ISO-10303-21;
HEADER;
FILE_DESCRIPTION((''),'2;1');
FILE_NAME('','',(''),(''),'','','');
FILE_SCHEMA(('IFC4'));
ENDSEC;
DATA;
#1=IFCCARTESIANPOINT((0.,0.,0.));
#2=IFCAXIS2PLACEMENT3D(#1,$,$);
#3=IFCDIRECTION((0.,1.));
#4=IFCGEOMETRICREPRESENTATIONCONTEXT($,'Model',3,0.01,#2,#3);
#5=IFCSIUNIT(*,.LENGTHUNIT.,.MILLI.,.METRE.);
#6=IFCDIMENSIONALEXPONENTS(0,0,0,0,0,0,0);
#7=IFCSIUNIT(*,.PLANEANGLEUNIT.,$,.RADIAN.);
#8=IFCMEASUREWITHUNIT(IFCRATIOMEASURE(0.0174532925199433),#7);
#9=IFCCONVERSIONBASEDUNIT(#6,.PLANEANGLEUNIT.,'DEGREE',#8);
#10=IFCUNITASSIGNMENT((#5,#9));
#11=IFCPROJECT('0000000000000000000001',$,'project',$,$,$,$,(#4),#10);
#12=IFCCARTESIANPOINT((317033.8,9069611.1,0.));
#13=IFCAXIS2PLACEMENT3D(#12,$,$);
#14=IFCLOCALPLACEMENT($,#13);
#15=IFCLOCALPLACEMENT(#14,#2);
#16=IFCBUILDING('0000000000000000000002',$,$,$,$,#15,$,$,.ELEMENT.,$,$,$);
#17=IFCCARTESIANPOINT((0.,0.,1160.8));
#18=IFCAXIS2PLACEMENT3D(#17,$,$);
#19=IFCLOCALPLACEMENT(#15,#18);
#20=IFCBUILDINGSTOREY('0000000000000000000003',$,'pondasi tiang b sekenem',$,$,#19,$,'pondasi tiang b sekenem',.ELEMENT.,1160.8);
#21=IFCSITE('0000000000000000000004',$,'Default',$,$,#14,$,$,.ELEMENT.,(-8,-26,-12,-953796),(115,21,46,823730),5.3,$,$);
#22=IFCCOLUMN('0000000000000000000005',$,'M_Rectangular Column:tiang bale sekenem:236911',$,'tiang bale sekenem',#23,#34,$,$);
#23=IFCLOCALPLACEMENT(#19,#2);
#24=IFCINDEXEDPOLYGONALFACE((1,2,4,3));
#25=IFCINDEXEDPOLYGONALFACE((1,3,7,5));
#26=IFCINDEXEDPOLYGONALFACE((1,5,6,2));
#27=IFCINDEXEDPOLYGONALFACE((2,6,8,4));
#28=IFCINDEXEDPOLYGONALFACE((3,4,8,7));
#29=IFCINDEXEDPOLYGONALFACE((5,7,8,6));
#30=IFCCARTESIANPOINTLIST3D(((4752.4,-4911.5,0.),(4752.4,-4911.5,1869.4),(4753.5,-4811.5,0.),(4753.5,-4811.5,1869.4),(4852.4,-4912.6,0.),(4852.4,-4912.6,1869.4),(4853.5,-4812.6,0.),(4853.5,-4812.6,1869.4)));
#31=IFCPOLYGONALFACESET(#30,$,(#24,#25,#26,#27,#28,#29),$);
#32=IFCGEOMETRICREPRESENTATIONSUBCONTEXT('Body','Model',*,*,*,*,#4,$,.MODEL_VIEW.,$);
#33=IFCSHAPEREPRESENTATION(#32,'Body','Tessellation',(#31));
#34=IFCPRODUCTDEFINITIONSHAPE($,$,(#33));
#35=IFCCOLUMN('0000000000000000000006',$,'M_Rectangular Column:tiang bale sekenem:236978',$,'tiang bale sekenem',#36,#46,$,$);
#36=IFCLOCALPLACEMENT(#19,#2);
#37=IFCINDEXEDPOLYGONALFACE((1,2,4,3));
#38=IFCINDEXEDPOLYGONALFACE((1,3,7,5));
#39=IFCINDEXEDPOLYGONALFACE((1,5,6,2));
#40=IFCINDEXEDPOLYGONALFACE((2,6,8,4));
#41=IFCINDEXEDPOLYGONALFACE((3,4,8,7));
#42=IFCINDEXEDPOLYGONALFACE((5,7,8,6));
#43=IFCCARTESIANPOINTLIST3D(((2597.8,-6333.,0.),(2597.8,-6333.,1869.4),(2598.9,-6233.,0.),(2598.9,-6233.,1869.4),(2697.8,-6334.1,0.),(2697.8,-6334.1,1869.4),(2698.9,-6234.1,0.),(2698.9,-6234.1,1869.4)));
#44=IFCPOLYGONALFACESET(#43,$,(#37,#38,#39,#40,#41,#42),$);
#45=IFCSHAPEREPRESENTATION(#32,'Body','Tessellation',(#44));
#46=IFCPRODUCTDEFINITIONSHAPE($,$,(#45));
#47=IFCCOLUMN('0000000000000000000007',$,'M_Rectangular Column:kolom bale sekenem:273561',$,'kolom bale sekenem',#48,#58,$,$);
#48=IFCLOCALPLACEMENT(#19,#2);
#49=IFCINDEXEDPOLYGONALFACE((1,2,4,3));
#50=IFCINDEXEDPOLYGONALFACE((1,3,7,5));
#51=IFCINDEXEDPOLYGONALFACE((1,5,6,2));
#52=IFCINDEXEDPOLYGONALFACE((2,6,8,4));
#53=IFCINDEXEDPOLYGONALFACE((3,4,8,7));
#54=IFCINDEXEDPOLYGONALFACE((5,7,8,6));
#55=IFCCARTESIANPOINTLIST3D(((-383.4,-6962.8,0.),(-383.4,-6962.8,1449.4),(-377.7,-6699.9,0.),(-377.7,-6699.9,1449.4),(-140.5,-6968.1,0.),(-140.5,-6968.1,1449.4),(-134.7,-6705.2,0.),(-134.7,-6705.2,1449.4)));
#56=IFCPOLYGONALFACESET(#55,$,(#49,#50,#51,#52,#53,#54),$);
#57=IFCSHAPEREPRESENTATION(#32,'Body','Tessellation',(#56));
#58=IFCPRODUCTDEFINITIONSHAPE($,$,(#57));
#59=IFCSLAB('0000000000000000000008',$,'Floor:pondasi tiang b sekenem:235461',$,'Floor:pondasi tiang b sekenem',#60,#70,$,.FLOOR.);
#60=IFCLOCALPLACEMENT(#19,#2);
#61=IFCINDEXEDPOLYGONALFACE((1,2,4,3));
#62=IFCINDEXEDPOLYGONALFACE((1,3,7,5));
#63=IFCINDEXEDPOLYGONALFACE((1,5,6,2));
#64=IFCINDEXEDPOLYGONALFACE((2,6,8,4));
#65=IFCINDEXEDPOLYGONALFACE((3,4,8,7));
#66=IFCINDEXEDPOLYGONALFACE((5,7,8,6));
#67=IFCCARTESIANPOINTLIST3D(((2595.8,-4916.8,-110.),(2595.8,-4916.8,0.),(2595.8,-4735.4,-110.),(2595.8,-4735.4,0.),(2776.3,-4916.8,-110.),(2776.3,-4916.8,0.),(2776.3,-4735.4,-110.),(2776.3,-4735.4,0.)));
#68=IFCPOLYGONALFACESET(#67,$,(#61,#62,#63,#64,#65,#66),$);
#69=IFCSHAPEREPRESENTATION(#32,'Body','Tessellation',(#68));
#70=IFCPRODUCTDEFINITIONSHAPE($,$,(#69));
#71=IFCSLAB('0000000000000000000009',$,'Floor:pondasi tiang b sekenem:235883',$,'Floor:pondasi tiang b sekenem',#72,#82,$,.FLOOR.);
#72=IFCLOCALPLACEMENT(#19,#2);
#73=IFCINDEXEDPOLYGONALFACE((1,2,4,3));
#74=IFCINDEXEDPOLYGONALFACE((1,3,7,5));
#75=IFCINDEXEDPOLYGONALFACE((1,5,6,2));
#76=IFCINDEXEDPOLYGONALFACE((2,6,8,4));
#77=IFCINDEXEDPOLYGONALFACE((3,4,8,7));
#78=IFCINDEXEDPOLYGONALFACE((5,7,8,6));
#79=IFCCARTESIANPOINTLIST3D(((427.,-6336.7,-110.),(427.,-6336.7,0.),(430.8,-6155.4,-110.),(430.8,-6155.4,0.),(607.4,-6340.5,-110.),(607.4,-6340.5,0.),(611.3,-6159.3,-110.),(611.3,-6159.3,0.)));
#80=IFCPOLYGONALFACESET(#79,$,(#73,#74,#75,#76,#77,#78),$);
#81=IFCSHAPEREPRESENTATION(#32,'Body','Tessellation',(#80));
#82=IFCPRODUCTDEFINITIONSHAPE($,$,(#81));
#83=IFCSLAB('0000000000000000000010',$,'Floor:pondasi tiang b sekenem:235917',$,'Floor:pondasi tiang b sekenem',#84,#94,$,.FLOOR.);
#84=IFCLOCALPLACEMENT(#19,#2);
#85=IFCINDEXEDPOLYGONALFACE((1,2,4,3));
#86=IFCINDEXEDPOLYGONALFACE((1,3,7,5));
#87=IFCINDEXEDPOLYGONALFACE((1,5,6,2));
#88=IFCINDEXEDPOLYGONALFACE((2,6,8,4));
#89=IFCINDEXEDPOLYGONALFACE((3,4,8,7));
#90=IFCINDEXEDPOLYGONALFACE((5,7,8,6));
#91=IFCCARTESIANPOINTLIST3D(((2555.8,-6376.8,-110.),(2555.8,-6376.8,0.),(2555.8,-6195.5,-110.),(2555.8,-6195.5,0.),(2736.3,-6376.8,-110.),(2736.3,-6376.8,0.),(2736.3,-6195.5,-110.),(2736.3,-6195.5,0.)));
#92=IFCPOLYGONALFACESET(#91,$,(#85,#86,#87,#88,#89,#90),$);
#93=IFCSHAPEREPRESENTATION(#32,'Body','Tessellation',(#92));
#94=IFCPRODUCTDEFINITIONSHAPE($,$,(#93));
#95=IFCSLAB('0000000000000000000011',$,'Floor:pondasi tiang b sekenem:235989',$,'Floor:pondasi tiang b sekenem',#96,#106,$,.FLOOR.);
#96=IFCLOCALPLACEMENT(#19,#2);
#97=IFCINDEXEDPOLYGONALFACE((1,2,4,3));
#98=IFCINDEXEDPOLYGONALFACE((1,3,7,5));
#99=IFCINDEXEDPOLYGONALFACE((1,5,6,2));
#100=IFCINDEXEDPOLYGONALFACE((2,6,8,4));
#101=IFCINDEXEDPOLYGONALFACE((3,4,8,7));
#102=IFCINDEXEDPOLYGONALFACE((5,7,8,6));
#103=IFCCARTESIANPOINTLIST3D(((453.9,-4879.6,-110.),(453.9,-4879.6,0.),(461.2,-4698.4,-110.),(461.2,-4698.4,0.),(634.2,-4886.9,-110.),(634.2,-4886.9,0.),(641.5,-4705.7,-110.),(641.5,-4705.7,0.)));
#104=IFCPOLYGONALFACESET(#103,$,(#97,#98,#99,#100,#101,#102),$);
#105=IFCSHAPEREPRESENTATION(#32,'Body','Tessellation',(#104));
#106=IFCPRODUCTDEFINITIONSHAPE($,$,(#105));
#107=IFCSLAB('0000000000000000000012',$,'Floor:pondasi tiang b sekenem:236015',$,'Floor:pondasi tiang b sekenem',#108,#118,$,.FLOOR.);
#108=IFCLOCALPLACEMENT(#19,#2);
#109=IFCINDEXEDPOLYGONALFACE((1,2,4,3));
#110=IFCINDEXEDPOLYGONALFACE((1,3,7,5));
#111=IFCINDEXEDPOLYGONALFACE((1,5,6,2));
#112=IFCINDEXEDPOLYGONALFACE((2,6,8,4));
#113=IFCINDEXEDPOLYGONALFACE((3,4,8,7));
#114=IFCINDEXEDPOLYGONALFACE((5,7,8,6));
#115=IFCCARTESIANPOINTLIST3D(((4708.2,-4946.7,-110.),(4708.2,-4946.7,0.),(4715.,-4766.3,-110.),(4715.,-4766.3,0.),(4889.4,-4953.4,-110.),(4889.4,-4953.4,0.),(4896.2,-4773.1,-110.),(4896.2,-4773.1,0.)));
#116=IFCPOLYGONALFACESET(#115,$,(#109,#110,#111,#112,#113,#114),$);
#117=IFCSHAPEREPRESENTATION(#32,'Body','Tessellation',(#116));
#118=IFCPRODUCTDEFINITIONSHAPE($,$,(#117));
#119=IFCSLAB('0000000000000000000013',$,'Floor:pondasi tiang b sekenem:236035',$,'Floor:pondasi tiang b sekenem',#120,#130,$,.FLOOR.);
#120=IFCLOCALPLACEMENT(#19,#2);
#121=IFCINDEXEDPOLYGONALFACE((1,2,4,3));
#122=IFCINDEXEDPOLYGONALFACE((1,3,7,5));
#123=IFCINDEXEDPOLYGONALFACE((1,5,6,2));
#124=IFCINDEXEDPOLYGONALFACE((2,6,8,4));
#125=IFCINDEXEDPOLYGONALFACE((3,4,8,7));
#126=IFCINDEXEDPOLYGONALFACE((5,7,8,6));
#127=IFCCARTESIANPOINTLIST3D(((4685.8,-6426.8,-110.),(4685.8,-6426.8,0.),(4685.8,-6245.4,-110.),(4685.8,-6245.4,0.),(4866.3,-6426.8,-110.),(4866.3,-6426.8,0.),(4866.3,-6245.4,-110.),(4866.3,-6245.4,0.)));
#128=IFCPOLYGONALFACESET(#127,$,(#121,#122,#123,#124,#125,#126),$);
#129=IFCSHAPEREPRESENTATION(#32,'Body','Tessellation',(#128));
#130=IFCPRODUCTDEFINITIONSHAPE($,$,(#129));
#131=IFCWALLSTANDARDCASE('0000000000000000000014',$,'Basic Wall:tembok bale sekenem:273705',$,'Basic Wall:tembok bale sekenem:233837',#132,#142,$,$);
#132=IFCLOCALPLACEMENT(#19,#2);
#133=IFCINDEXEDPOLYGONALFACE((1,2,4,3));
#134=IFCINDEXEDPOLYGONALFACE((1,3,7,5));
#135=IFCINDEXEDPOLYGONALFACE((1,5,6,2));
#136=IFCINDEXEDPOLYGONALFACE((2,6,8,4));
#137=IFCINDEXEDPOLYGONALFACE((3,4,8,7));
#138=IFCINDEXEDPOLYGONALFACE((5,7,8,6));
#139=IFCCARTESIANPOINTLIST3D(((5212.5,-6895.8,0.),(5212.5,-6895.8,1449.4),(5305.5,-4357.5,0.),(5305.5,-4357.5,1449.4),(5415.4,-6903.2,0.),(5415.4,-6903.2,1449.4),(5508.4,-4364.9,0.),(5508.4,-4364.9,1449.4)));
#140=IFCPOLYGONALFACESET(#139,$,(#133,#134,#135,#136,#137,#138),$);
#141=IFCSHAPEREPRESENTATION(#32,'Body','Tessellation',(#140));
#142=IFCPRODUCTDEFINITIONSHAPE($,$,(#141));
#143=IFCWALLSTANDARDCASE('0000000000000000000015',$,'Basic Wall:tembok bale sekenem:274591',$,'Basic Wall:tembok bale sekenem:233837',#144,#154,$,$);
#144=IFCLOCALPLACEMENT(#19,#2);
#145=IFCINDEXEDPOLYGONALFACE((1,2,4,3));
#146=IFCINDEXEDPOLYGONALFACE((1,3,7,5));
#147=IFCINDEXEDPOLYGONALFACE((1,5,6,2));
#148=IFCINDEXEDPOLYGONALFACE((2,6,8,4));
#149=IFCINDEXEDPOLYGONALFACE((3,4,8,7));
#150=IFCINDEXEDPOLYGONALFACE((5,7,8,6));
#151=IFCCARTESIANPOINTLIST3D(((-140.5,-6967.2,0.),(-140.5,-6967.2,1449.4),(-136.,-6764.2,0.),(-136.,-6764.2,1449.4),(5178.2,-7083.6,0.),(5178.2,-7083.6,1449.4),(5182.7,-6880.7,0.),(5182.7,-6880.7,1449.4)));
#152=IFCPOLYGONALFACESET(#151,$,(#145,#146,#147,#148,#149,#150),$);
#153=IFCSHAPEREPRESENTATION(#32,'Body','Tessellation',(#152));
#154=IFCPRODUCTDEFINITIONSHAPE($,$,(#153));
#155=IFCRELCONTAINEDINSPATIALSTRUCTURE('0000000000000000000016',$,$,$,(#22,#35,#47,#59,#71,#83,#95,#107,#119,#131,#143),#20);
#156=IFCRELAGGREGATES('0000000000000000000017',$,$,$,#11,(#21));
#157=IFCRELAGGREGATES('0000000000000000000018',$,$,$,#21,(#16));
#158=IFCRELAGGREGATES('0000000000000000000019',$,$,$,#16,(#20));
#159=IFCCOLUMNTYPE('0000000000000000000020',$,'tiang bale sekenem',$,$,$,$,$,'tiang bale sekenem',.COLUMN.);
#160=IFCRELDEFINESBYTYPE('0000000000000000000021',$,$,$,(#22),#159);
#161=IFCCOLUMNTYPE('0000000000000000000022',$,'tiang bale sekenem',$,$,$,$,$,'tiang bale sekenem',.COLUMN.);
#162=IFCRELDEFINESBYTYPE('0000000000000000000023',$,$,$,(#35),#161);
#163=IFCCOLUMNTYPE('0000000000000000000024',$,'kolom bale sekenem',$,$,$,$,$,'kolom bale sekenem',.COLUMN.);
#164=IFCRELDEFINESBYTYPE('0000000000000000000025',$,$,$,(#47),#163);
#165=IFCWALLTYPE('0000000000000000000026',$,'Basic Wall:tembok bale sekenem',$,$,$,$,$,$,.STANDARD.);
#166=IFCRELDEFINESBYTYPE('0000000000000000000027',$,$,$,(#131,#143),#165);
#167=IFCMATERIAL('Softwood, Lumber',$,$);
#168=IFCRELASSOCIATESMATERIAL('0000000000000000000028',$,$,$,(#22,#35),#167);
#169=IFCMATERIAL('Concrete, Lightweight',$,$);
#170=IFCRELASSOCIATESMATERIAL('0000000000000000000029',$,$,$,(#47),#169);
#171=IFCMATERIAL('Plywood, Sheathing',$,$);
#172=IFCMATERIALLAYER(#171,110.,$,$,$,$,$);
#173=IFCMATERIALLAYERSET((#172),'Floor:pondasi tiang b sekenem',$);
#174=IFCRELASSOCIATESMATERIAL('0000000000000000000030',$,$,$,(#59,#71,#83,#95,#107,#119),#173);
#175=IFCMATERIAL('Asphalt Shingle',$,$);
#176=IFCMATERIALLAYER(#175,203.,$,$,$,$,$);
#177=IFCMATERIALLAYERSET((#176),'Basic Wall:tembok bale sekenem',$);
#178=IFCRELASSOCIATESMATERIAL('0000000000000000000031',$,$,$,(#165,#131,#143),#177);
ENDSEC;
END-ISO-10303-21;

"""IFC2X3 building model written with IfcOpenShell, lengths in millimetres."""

from ifc_helpers import new_model, entity, si_unit, converted_unit, direction, frame, frame_2d, origin, origin_2d_with_axis, place, context, subcontext, project, spatial, rectangle, extrude, source, transform, mapped, material, layer, layer_set, layer_usage, type_object, type_shapes, element, save


model = new_model("IFC2X3")

# Units and contexts
model_context = context("Model", 3, precision=0.01, world=origin(), true_north=direction((0.0, 1.0)))
body_context = subcontext(model_context, "Body", "Model", "MODEL_VIEW")
ifc_project = project(units=[si_unit("LENGTHUNIT", "METRE", prefix="MILLI"), converted_unit("PLANEANGLEUNIT", "DEGREE", entity("IfcRatioMeasure", 0.0174532925199433), si_unit("PLANEANGLEUNIT", "RADIAN"), dimensions=[0, 0, 0, 0, 0, 0, 0])], contexts=[model_context])

# Site, building, storey
site_placement = place(None, frame((317033.8, 9069611.1, 0.0)))
site = spatial("IfcSite", under=ifc_project, at=site_placement, Name="Default", CompositionType="ELEMENT", RefLatitude=(-8, -26, -12, -953796), RefLongitude=(115, 21, 46, 823730), RefElevation=5.3)
building_placement = place(site_placement, origin())
building = spatial("IfcBuilding", under=site, at=building_placement, CompositionType="ELEMENT")
storey_placement = place(building_placement, frame((0.0, 0.0, 1160.8)))
storey = spatial("IfcBuildingStorey", under=building, at=storey_placement, Name="pondasi tiang b sekenem", LongName="pondasi tiang b sekenem", CompositionType="ELEMENT", Elevation=1160.8)

# Columns
ifc_material_1 = material(Name="Softwood, Lumber")
column_type_1 = type_object("IfcColumnType", Name="tiang bale sekenem", ElementType="tiang bale sekenem", PredefinedType="COLUMN")
shared_shape_1 = source(origin(), body_context, "Body", "SweptSolid", [
    extrude(rectangle(XDim=100.0, YDim=100.0, at=frame_2d((0.0, 0.0), x_axis=(1.0, 0.0))), frame((4803.0, -4862.1, 1160.8), z_axis=(0.0, 0.0, 1.0), x_axis=(-0.999937, 0.011261, 0.0)), (0.0, 0.0, 1.0), 1869.4),
])
type_shapes(column_type_1, [shared_shape_1])
column_1_placement = place(storey_placement, frame((0.0, 0.0, -1160.8)))
element("IfcColumn", 1, at=column_1_placement, inside=storey, type_object=column_type_1, material=ifc_material_1, Name="M_Rectangular Column:tiang bale sekenem:236911", ObjectType="tiang bale sekenem", context=body_context, shape_type="MappedRepresentation", body=[
    mapped(shared_shape_1, transform((0.0, 0.0, 0.0), scale=1.0)),
])
column_type_2 = type_object("IfcColumnType", Name="tiang bale sekenem", ElementType="tiang bale sekenem", PredefinedType="COLUMN")
shared_shape_2 = source(origin(), body_context, "Body", "SweptSolid", [
    extrude(rectangle(XDim=100.0, YDim=100.0, at=origin_2d_with_axis()), frame((2648.4, -6283.5, 1160.8), z_axis=(0.0, 0.0, 1.0), x_axis=(-0.999937, 0.011261, 0.0)), (0.0, 0.0, 1.0), 1869.4),
])
type_shapes(column_type_2, [shared_shape_2])
column_2_placement = place(storey_placement, frame((0.0, 0.0, -1160.8)))
element("IfcColumn", 2, at=column_2_placement, inside=storey, type_object=column_type_2, material=ifc_material_1, Name="M_Rectangular Column:tiang bale sekenem:236978", ObjectType="tiang bale sekenem", context=body_context, shape_type="MappedRepresentation", body=[
    mapped(shared_shape_2, transform((0.0, 0.0, 0.0), scale=1.0)),
])
ifc_material_2 = material(Name="Concrete, Lightweight")
column_type_3 = type_object("IfcColumnType", Name="kolom bale sekenem", ElementType="kolom bale sekenem", PredefinedType="COLUMN")
shared_shape_3 = source(origin(), body_context, "Body", "SweptSolid", [
    extrude(rectangle(XDim=243.0, YDim=263.0, at=frame_2d((0.0, 0.0), x_axis=(1.0, 0.0))), frame((-259.1, -6834.0, 1160.8), z_axis=(0.0, 0.0, 1.0), x_axis=(-0.999761, 0.021885, 0.0)), (0.0, 0.0, 1.0), 1449.4),
])
type_shapes(column_type_3, [shared_shape_3])
column_3_placement = place(storey_placement, frame((0.0, 0.0, -1160.8)))
element("IfcColumn", 3, at=column_3_placement, inside=storey, type_object=column_type_3, material=ifc_material_2, Name="M_Rectangular Column:kolom bale sekenem:273561", ObjectType="kolom bale sekenem", context=body_context, shape_type="MappedRepresentation", body=[
    mapped(shared_shape_3, transform((0.0, 0.0, 0.0), scale=1.0)),
])

# Slabs
ifc_material_3 = material(Name="Plywood, Sheathing")
ifc_layer_1 = layer(ifc_material_3, 110.0)
ifc_layer_set_1 = layer_set([ifc_layer_1], Name="Floor:pondasi tiang b sekenem")
ifc_layer_usage_1 = layer_usage(ifc_layer_set_1, "AXIS3", "POSITIVE", 0.0)
slab_1_placement = place(storey_placement, origin())
element("IfcSlab", 4, at=slab_1_placement, inside=storey, material=ifc_layer_usage_1, Name="Floor:pondasi tiang b sekenem:235461", ObjectType="Floor:pondasi tiang b sekenem", PredefinedType="FLOOR", context=body_context, shape_type="SweptSolid", body=[
    extrude(rectangle(XDim=181.3, YDim=180.5, at=frame_2d((0.0, 0.0), x_axis=(1.0, 0.0))), frame((2686.1, -4826.1, 0.0), z_axis=(0.0, 0.0, -1.0), x_axis=(0.0, 1.0, 0.0)), (0.0, 0.0, 1.0), 110.0),
])
ifc_layer_usage_2 = layer_usage(ifc_layer_set_1, "AXIS3", "POSITIVE", 0.0)
slab_2_placement = place(storey_placement, origin())
element("IfcSlab", 5, at=slab_2_placement, inside=storey, material=ifc_layer_usage_2, Name="Floor:pondasi tiang b sekenem:235883", ObjectType="Floor:pondasi tiang b sekenem", PredefinedType="FLOOR", context=body_context, shape_type="SweptSolid", body=[
    extrude(rectangle(XDim=181.3, YDim=180.5, at=frame_2d((0.0, 0.0), x_axis=(1.0, 0.0))), frame((519.1, -6248.0, 0.0), z_axis=(0.0, 0.0, -1.0), x_axis=(-0.021131, -0.999777, 0.0)), (0.0, 0.0, 1.0), 110.0),
])
ifc_layer_usage_3 = layer_usage(ifc_layer_set_1, "AXIS3", "POSITIVE", 0.0)
slab_3_placement = place(storey_placement, origin())
element("IfcSlab", 6, at=slab_3_placement, inside=storey, material=ifc_layer_usage_3, Name="Floor:pondasi tiang b sekenem:235917", ObjectType="Floor:pondasi tiang b sekenem", PredefinedType="FLOOR", context=body_context, shape_type="SweptSolid", body=[
    extrude(rectangle(XDim=181.3, YDim=180.5, at=frame_2d((0.0, 0.0), x_axis=(1.0, 0.0))), frame((2646.1, -6286.2, 0.0), z_axis=(0.0, 0.0, -1.0), x_axis=(0.0, 1.0, 0.0)), (0.0, 0.0, 1.0), 110.0),
])
ifc_layer_usage_4 = layer_usage(ifc_layer_set_1, "AXIS3", "POSITIVE", 0.0)
slab_4_placement = place(storey_placement, origin())
element("IfcSlab", 7, at=slab_4_placement, inside=storey, material=ifc_layer_usage_4, Name="Floor:pondasi tiang b sekenem:235989", ObjectType="Floor:pondasi tiang b sekenem", PredefinedType="FLOOR", context=body_context, shape_type="SweptSolid", body=[
    extrude(rectangle(XDim=181.3, YDim=180.5, at=frame_2d((0.0, 0.0), x_axis=(1.0, 0.0))), frame((547.7, -4792.7, 0.0), z_axis=(0.0, 0.0, -1.0), x_axis=(-0.040145, -0.999194, 0.0)), (0.0, 0.0, 1.0), 110.0),
])
ifc_layer_usage_5 = layer_usage(ifc_layer_set_1, "AXIS3", "POSITIVE", 0.0)
slab_5_placement = place(storey_placement, origin())
element("IfcSlab", 8, at=slab_5_placement, inside=storey, material=ifc_layer_usage_5, Name="Floor:pondasi tiang b sekenem:236015", ObjectType="Floor:pondasi tiang b sekenem", PredefinedType="FLOOR", context=body_context, shape_type="SweptSolid", body=[
    extrude(rectangle(XDim=180.5, YDim=181.3, at=frame_2d((0.0, 0.0), x_axis=(1.0, 0.0))), frame((4802.2, -4859.9, 0.0), z_axis=(0.0, 0.0, -1.0), x_axis=(-0.037386, -0.999301, 0.0)), (0.0, 0.0, 1.0), 110.0),
])
ifc_layer_usage_6 = layer_usage(ifc_layer_set_1, "AXIS3", "POSITIVE", 0.0)
slab_6_placement = place(storey_placement, origin())
element("IfcSlab", 9, at=slab_6_placement, inside=storey, material=ifc_layer_usage_6, Name="Floor:pondasi tiang b sekenem:236035", ObjectType="Floor:pondasi tiang b sekenem", PredefinedType="FLOOR", context=body_context, shape_type="SweptSolid", body=[
    extrude(rectangle(XDim=181.3, YDim=180.5, at=origin_2d_with_axis()), frame((4776.1, -6336.1, 0.0), z_axis=(0.0, 0.0, -1.0), x_axis=(0.0, 1.0, 0.0)), (0.0, 0.0, 1.0), 110.0),
])

# Walls
ifc_material_4 = material(Name="Asphalt Shingle")
ifc_layer_2 = layer(ifc_material_4, 203.0)
ifc_layer_set_2 = layer_set([ifc_layer_2], Name="Basic Wall:tembok bale sekenem")
ifc_layer_usage_7 = layer_usage(ifc_layer_set_2, "AXIS2", "NEGATIVE", 101.5)
wall_type = type_object("IfcWallType", Name="Basic Wall:tembok bale sekenem", PredefinedType="STANDARD", material=ifc_layer_set_2)
wall_1_placement = place(storey_placement, frame((5406.9, -4361.2, 0.0), z_axis=(0.0, 0.0, 1.0), x_axis=(-0.036607, -0.99933, 0.0)))
element("IfcWallStandardCase", 10, at=wall_1_placement, inside=storey, type_object=wall_type, material=ifc_layer_usage_7, Name="Basic Wall:tembok bale sekenem:273705", ObjectType="Basic Wall:tembok bale sekenem:233837", context=body_context, shape_type="SweptSolid", body=[
    extrude(rectangle(XDim=2540.0, YDim=203.0, at=frame_2d((1270.0, 0.0), x_axis=(-1.0, 0.0))), origin(), (0.0, 0.0, 1.0), 1449.4),
])
ifc_layer_usage_8 = layer_usage(ifc_layer_set_2, "AXIS2", "NEGATIVE", 101.5)
wall_2_placement = place(storey_placement, frame((5180.5, -6982.1, 0.0), z_axis=(0.0, 0.0, 1.0), x_axis=(-0.999761, 0.021885, 0.0)))
element("IfcWallStandardCase", 11, at=wall_2_placement, inside=storey, type_object=wall_type, material=ifc_layer_usage_8, Name="Basic Wall:tembok bale sekenem:274591", ObjectType="Basic Wall:tembok bale sekenem:233837", context=body_context, shape_type="SweptSolid", body=[
    extrude(rectangle(XDim=5320.0, YDim=203.0, at=frame_2d((2660.0, 0.0), x_axis=(-1.0, 0.0))), origin(), (0.0, 0.0, 1.0), 1449.4),
])

save(model, "model.ifc")
